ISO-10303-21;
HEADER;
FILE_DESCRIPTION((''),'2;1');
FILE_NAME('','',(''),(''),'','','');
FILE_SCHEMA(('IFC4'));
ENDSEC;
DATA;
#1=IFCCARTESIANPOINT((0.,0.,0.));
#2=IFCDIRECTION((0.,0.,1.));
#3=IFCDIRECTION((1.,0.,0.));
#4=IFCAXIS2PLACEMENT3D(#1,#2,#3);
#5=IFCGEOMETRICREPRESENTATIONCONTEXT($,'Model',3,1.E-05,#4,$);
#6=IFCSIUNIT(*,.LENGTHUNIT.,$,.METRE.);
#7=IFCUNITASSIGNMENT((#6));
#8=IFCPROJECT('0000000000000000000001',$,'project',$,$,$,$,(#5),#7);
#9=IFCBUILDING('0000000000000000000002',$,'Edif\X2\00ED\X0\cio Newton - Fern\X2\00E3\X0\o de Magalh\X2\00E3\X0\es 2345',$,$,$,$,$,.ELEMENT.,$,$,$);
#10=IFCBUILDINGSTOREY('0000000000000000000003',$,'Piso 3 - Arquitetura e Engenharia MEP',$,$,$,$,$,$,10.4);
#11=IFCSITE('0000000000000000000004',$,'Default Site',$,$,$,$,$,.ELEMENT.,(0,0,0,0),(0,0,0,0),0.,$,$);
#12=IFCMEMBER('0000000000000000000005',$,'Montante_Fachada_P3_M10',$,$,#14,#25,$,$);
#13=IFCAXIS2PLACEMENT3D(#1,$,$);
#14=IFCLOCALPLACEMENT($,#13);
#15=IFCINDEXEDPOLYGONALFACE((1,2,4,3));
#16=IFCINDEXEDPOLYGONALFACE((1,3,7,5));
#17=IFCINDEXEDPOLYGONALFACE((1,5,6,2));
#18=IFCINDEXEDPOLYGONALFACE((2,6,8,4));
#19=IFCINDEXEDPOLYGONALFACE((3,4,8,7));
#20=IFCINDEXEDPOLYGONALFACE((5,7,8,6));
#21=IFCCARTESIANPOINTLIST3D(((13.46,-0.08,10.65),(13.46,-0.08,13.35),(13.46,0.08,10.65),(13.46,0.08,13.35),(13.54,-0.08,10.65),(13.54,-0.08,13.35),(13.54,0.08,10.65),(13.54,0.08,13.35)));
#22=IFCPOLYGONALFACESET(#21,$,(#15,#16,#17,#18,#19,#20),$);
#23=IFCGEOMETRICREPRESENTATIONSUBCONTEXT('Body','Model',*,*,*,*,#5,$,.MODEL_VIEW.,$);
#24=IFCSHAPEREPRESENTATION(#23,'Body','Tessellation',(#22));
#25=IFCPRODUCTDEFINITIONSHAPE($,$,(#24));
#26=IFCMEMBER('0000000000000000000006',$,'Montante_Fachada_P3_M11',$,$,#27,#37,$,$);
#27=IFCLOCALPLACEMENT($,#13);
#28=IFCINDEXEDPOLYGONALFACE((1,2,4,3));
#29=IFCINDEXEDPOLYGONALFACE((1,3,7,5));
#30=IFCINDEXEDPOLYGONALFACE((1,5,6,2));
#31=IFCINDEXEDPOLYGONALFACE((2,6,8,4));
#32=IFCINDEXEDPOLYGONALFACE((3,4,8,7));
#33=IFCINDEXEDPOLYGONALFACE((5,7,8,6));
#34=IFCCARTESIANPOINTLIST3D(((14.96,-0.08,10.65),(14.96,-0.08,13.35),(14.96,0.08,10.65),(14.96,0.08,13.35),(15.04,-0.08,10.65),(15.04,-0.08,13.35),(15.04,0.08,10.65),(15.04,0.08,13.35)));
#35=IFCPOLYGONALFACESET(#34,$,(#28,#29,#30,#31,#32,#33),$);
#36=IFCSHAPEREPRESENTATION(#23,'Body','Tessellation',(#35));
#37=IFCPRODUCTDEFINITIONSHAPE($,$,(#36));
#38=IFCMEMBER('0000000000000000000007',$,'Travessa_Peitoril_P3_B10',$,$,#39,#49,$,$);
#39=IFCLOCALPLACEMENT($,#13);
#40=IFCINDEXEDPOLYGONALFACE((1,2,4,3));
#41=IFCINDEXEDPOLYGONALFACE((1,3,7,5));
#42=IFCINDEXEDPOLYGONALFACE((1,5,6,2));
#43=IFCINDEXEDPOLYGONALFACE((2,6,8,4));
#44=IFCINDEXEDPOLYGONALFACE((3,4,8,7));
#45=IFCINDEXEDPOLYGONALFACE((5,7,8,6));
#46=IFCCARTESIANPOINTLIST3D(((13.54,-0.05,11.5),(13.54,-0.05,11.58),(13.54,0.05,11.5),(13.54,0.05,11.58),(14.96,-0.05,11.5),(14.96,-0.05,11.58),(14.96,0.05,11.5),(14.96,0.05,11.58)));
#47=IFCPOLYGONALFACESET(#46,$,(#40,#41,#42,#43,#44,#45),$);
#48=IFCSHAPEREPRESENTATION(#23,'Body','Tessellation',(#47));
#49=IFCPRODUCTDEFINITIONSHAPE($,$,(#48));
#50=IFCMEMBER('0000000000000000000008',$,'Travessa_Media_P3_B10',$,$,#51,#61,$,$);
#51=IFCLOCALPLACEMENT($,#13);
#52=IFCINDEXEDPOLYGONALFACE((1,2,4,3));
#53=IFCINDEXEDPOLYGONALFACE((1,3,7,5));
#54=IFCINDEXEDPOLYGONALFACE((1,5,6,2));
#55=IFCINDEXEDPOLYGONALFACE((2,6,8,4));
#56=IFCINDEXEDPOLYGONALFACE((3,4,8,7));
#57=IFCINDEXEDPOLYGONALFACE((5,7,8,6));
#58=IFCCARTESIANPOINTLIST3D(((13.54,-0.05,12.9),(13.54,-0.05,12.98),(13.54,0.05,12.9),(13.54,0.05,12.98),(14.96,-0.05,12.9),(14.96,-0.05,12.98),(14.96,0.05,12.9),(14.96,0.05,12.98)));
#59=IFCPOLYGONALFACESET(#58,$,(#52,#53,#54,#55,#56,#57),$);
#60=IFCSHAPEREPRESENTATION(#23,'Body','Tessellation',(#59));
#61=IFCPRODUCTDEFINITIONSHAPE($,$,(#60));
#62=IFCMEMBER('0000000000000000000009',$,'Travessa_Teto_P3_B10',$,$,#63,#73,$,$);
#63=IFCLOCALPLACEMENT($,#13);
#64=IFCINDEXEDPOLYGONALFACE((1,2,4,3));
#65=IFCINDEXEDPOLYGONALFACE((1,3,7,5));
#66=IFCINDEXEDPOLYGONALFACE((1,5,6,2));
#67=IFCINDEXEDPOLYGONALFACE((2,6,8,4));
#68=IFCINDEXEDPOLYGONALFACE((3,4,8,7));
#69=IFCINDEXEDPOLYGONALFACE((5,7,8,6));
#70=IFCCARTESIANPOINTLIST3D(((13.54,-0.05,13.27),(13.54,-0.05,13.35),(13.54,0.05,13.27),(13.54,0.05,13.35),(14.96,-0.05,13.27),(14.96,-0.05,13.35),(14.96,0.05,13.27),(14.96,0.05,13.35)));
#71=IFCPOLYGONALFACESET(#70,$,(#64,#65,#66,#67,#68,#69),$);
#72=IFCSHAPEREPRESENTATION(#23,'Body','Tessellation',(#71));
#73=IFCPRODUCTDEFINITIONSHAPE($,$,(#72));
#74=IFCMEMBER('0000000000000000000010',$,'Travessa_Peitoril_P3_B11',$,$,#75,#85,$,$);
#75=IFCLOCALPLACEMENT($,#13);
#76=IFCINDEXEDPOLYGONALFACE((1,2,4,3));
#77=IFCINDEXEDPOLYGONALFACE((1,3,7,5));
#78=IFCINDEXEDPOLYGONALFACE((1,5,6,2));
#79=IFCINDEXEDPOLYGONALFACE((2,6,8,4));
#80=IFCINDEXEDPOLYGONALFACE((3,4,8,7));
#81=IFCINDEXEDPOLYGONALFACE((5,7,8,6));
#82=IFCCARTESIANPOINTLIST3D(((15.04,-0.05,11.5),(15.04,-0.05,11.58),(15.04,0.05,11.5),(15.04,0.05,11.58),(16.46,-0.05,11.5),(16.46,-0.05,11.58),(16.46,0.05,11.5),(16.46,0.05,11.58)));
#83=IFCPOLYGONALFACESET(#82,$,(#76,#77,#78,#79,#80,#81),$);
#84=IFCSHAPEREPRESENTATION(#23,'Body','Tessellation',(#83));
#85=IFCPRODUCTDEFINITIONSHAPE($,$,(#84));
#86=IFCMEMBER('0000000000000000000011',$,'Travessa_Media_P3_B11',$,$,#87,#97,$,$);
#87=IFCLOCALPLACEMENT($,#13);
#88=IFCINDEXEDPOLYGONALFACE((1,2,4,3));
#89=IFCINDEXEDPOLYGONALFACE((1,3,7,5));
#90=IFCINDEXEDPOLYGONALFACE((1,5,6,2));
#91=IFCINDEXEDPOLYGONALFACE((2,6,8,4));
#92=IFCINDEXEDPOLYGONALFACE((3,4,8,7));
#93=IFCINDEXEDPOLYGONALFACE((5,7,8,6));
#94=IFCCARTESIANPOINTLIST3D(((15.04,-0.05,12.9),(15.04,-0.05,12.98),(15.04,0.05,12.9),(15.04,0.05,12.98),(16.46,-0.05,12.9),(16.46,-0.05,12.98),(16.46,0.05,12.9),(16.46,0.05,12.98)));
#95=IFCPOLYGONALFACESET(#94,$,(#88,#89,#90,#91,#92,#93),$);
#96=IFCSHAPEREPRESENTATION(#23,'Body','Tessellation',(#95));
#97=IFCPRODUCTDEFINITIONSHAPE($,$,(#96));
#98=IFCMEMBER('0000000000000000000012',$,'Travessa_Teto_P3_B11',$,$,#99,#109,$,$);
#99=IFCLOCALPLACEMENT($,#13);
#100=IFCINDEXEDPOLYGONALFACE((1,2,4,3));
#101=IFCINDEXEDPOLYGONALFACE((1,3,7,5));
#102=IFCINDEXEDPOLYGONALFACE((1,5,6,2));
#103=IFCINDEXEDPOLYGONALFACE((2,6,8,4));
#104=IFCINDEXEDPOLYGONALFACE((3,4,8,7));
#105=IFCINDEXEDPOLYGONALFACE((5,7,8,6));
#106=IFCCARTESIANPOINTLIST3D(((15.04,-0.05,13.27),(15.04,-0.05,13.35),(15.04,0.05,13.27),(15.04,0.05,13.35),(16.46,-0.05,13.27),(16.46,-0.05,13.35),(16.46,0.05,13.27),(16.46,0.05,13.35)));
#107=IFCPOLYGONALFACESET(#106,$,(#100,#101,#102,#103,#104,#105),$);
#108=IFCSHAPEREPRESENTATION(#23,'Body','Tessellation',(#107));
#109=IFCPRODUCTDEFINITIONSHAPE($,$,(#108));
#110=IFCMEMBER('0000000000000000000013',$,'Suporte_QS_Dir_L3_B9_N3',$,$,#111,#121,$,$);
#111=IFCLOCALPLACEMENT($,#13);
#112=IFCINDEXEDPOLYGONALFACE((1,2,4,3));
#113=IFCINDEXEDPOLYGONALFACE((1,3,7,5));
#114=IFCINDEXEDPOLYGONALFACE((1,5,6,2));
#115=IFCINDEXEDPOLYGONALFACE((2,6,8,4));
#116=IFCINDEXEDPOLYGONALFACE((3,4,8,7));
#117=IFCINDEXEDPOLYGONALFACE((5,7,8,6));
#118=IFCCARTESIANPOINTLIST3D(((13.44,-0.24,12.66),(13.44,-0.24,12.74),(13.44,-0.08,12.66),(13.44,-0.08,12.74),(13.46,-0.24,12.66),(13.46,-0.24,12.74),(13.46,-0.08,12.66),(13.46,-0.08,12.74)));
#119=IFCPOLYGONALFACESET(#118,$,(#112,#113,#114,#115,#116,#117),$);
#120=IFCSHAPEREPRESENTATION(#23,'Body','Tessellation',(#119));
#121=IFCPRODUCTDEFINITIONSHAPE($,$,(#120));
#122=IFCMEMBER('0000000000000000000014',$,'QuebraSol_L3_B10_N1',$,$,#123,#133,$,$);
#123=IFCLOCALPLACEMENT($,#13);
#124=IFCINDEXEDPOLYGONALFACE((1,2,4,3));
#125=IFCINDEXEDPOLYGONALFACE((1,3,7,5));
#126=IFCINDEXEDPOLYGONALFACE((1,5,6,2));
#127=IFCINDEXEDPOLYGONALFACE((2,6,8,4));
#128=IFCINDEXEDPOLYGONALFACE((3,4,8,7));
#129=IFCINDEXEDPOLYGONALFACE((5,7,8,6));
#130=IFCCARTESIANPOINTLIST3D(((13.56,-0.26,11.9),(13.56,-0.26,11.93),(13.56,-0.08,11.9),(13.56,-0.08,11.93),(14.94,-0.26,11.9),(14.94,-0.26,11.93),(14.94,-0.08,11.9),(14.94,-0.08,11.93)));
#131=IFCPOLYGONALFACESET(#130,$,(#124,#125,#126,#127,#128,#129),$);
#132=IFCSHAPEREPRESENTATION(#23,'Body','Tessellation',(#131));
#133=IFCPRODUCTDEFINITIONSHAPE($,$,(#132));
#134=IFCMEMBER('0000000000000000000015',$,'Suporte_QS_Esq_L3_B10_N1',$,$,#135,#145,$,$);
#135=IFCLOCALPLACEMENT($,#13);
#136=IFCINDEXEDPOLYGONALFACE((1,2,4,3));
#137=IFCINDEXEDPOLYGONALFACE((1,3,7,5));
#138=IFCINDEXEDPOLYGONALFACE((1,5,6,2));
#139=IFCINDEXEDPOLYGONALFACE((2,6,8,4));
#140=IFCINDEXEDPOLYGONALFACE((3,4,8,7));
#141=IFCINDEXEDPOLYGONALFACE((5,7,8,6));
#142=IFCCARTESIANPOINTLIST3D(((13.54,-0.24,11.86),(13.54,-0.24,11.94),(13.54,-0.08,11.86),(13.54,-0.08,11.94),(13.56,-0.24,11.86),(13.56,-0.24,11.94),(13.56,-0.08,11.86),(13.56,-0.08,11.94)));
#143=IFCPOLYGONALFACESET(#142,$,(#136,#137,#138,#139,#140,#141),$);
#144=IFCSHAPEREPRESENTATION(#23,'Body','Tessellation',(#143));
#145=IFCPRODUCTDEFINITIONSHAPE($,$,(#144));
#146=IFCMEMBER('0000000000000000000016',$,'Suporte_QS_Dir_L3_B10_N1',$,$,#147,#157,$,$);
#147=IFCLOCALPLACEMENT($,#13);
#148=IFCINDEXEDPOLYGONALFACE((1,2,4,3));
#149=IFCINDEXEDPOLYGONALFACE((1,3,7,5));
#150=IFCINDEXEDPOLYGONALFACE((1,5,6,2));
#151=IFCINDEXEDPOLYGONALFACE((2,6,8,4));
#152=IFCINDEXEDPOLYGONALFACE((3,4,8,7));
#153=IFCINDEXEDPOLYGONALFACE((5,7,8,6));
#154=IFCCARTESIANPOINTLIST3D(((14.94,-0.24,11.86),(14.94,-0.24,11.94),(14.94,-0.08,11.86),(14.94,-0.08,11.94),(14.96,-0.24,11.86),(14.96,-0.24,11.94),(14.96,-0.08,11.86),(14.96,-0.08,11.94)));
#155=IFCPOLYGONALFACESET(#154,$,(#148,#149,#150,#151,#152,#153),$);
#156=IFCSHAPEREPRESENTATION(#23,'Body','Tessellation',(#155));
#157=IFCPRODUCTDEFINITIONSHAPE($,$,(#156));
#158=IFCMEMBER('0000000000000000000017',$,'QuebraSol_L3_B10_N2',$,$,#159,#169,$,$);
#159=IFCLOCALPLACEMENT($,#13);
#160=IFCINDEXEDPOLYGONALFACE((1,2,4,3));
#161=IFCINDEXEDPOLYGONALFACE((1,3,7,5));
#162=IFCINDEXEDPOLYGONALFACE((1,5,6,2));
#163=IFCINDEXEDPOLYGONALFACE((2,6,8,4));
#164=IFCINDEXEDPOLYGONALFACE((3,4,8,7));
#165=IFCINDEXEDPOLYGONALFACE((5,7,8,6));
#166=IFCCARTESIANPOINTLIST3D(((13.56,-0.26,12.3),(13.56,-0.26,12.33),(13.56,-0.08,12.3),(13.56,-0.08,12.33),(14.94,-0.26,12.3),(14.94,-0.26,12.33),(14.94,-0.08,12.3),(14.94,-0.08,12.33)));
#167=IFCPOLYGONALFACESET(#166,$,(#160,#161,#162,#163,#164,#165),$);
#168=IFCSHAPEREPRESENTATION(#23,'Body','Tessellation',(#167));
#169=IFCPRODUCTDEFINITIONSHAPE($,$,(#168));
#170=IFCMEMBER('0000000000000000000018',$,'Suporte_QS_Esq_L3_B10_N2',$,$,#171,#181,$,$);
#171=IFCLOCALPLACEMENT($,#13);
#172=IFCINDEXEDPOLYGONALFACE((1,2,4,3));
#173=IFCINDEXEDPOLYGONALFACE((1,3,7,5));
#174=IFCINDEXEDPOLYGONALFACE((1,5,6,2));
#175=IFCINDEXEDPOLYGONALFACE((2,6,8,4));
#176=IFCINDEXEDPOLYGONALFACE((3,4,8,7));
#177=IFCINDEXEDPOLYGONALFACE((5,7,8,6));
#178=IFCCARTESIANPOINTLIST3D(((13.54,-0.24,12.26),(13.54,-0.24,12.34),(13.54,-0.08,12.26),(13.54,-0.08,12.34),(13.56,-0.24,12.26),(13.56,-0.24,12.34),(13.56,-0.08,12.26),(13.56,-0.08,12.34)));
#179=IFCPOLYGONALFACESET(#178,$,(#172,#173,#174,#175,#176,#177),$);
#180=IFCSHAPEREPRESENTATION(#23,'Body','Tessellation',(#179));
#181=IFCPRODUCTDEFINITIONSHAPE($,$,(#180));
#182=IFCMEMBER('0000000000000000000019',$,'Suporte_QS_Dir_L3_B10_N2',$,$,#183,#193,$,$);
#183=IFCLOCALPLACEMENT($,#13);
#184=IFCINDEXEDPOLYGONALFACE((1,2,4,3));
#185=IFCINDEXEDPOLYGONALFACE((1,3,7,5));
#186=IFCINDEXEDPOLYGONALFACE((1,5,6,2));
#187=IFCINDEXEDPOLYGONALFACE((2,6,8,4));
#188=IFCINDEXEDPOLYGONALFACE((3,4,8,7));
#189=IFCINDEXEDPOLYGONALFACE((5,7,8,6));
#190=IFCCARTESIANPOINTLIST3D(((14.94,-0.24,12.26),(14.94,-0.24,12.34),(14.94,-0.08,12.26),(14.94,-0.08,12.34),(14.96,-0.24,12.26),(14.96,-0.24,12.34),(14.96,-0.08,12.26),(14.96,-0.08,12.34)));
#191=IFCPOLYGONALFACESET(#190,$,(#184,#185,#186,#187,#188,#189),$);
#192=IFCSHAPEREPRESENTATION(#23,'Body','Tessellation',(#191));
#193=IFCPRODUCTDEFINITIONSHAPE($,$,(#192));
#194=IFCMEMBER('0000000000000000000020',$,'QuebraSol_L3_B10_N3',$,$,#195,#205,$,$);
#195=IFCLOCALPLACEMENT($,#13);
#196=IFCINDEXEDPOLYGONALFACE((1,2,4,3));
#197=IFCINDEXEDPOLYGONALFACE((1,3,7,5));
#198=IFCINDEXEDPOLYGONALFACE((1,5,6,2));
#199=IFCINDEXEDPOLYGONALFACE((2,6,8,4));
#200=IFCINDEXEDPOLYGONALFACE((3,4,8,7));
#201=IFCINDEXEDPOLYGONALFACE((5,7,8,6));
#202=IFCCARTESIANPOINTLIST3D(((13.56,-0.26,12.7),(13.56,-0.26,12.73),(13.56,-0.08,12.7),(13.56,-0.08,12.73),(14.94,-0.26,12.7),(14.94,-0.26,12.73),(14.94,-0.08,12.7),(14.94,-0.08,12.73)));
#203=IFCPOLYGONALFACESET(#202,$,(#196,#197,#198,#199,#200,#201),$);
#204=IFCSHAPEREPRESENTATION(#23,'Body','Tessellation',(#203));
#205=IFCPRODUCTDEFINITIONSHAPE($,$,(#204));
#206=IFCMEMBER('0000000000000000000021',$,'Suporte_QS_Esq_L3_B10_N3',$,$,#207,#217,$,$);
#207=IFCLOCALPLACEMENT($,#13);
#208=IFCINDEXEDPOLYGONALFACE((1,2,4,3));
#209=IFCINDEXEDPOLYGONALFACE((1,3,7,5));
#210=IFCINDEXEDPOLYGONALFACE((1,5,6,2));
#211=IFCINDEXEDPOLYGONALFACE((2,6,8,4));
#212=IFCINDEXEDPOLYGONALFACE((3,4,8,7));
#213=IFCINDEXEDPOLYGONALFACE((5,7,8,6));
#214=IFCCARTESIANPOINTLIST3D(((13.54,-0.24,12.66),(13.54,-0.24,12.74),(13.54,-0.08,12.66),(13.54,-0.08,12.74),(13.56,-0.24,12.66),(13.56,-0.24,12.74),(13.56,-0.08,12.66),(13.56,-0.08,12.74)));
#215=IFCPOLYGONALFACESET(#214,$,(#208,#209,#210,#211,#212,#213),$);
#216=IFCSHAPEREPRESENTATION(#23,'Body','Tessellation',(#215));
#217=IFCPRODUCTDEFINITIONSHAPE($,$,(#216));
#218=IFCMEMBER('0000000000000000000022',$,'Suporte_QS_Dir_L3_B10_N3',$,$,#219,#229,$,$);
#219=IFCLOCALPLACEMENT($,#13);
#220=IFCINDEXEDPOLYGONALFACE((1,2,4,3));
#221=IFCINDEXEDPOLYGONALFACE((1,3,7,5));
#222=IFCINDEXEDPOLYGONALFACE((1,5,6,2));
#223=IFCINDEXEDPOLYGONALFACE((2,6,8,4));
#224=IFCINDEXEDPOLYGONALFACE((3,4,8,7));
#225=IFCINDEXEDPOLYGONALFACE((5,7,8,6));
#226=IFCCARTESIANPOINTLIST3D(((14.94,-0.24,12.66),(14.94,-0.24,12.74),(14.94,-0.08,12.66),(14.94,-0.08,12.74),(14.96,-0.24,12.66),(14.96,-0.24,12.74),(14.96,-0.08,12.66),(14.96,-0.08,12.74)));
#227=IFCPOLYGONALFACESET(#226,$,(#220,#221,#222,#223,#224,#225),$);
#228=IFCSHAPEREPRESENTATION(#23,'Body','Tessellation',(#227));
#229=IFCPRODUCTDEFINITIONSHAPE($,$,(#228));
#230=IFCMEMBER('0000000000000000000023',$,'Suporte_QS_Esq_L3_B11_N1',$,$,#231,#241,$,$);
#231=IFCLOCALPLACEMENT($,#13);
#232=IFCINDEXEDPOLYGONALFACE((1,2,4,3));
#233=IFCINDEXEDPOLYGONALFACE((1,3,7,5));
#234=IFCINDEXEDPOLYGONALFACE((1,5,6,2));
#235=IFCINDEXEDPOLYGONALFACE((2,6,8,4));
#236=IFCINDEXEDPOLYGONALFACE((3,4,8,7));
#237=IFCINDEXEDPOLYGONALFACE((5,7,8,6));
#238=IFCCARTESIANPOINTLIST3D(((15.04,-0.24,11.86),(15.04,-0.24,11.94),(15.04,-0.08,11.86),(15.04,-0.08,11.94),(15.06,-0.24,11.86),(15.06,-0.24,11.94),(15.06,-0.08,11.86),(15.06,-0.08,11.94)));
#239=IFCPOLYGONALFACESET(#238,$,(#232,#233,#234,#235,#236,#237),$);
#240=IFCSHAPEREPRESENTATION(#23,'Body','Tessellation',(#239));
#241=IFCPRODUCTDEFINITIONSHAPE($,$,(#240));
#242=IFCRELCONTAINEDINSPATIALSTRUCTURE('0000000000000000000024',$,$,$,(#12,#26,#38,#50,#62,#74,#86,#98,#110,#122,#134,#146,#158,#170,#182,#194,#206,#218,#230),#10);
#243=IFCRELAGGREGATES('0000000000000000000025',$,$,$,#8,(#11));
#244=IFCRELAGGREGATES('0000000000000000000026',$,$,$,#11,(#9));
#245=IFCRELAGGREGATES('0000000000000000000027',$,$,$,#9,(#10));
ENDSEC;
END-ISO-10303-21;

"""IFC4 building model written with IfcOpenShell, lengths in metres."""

from ifc_helpers import new_model, si_unit, frame, frame_2d, origin_with_axes, place, context, subcontext, project, spatial, rectangle, extrude, element, save


model = new_model("IFC4")

# Units and contexts
model_context = context("Model", 3, precision=1e-05, world=origin_with_axes())
body_context = subcontext(model_context, "Body", "Model", "MODEL_VIEW")
ifc_project = project(units=[si_unit("LENGTHUNIT", "METRE")], contexts=[model_context])

# Site, building, storey
site = spatial("IfcSite", under=ifc_project, Name="Default Site", CompositionType="ELEMENT", RefLatitude=(0, 0, 0, 0), RefLongitude=(0, 0, 0, 0), RefElevation=0.0)
building = spatial("IfcBuilding", under=site, Name="Edifício Newton - Fernão de Magalhães 2345", CompositionType="ELEMENT")
storey = spatial("IfcBuildingStorey", under=building, Name="Piso 3 - Arquitetura e Engenharia MEP", Elevation=10.4)

# Members
for number, where, z_axis, x_axis, name in (
    (1, (13.46, -0.08, 10.65), (0.0, 0.0, 1.0), (1.0, 0.0, 0.0), "Montante_Fachada_P3_M10"),
    (2, (14.96, -0.08, 10.65), (0.0, 0.0, 1.0), (1.0, 0.0, 0.0), "Montante_Fachada_P3_M11"),
):
    element("IfcMember", number, at=place(None, frame(where, z_axis=z_axis, x_axis=x_axis)), inside=storey, Name=name, context=body_context, shape_type="SweptSolid", body=[
        extrude(rectangle(XDim=0.08, YDim=0.16, at=frame_2d((0.04, 0.08))), origin_with_axes(), (0.0, 0.0, 1.0), 2.7),
    ])
for number, where, z_axis, x_axis, name in (
    (3, (13.54, -0.05, 11.5), (0.0, 0.0, 1.0), (1.0, 0.0, 0.0), "Travessa_Peitoril_P3_B10"),
    (4, (13.54, -0.05, 12.9), (0.0, 0.0, 1.0), (1.0, 0.0, 0.0), "Travessa_Media_P3_B10"),
    (5, (13.54, -0.05, 13.27), (0.0, 0.0, 1.0), (1.0, 0.0, 0.0), "Travessa_Teto_P3_B10"),
    (6, (15.04, -0.05, 11.5), (0.0, 0.0, 1.0), (1.0, 0.0, 0.0), "Travessa_Peitoril_P3_B11"),
    (7, (15.04, -0.05, 12.9), (0.0, 0.0, 1.0), (1.0, 0.0, 0.0), "Travessa_Media_P3_B11"),
    (8, (15.04, -0.05, 13.27), (0.0, 0.0, 1.0), (1.0, 0.0, 0.0), "Travessa_Teto_P3_B11"),
):
    element("IfcMember", number, at=place(None, frame(where, z_axis=z_axis, x_axis=x_axis)), inside=storey, Name=name, context=body_context, shape_type="SweptSolid", body=[
        extrude(rectangle(XDim=1.42, YDim=0.1, at=frame_2d((0.71, 0.05))), origin_with_axes(), (0.0, 0.0, 1.0), 0.08),
    ])
member_1_placement = place(None, frame((13.44, -0.24, 12.66), z_axis=(0.0, 0.0, 1.0), x_axis=(1.0, 0.0, 0.0)))
element("IfcMember", 9, at=member_1_placement, inside=storey, Name="Suporte_QS_Dir_L3_B9_N3", context=body_context, shape_type="SweptSolid", body=[
    extrude(rectangle(XDim=0.02, YDim=0.16, at=frame_2d((0.01, 0.08))), origin_with_axes(), (0.0, 0.0, 1.0), 0.08),
])
member_2_placement = place(None, frame((13.56, -0.26, 11.9), z_axis=(0.0, 0.0, 1.0), x_axis=(1.0, 0.0, 0.0)))
element("IfcMember", 10, at=member_2_placement, inside=storey, Name="QuebraSol_L3_B10_N1", context=body_context, shape_type="SweptSolid", body=[
    extrude(rectangle(XDim=1.38, YDim=0.18, at=frame_2d((0.69, 0.09))), origin_with_axes(), (0.0, 0.0, 1.0), 0.03),
])
for number, where, z_axis, x_axis, name in (
    (11, (13.54, -0.24, 11.86), (0.0, 0.0, 1.0), (1.0, 0.0, 0.0), "Suporte_QS_Esq_L3_B10_N1"),
    (12, (14.94, -0.24, 11.86), (0.0, 0.0, 1.0), (1.0, 0.0, 0.0), "Suporte_QS_Dir_L3_B10_N1"),
):
    element("IfcMember", number, at=place(None, frame(where, z_axis=z_axis, x_axis=x_axis)), inside=storey, Name=name, context=body_context, shape_type="SweptSolid", body=[
        extrude(rectangle(XDim=0.02, YDim=0.16, at=frame_2d((0.01, 0.08))), origin_with_axes(), (0.0, 0.0, 1.0), 0.08),
    ])
member_3_placement = place(None, frame((13.56, -0.26, 12.3), z_axis=(0.0, 0.0, 1.0), x_axis=(1.0, 0.0, 0.0)))
element("IfcMember", 13, at=member_3_placement, inside=storey, Name="QuebraSol_L3_B10_N2", context=body_context, shape_type="SweptSolid", body=[
    extrude(rectangle(XDim=1.38, YDim=0.18, at=frame_2d((0.69, 0.09))), origin_with_axes(), (0.0, 0.0, 1.0), 0.03),
])
for number, where, z_axis, x_axis, name in (
    (14, (13.54, -0.24, 12.26), (0.0, 0.0, 1.0), (1.0, 0.0, 0.0), "Suporte_QS_Esq_L3_B10_N2"),
    (15, (14.94, -0.24, 12.26), (0.0, 0.0, 1.0), (1.0, 0.0, 0.0), "Suporte_QS_Dir_L3_B10_N2"),
):
    element("IfcMember", number, at=place(None, frame(where, z_axis=z_axis, x_axis=x_axis)), inside=storey, Name=name, context=body_context, shape_type="SweptSolid", body=[
        extrude(rectangle(XDim=0.02, YDim=0.16, at=frame_2d((0.01, 0.08))), origin_with_axes(), (0.0, 0.0, 1.0), 0.08),
    ])
member_4_placement = place(None, frame((13.56, -0.26, 12.7), z_axis=(0.0, 0.0, 1.0), x_axis=(1.0, 0.0, 0.0)))
element("IfcMember", 16, at=member_4_placement, inside=storey, Name="QuebraSol_L3_B10_N3", context=body_context, shape_type="SweptSolid", body=[
    extrude(rectangle(XDim=1.38, YDim=0.18, at=frame_2d((0.69, 0.09))), origin_with_axes(), (0.0, 0.0, 1.0), 0.03),
])
for number, where, z_axis, x_axis, name in (
    (17, (13.54, -0.24, 12.66), (0.0, 0.0, 1.0), (1.0, 0.0, 0.0), "Suporte_QS_Esq_L3_B10_N3"),
    (18, (14.94, -0.24, 12.66), (0.0, 0.0, 1.0), (1.0, 0.0, 0.0), "Suporte_QS_Dir_L3_B10_N3"),
    (19, (15.04, -0.24, 11.86), (0.0, 0.0, 1.0), (1.0, 0.0, 0.0), "Suporte_QS_Esq_L3_B11_N1"),
):
    element("IfcMember", number, at=place(None, frame(where, z_axis=z_axis, x_axis=x_axis)), inside=storey, Name=name, context=body_context, shape_type="SweptSolid", body=[
        extrude(rectangle(XDim=0.02, YDim=0.16, at=frame_2d((0.01, 0.08))), origin_with_axes(), (0.0, 0.0, 1.0), 0.08),
    ])

save(model, "model.ifc")
